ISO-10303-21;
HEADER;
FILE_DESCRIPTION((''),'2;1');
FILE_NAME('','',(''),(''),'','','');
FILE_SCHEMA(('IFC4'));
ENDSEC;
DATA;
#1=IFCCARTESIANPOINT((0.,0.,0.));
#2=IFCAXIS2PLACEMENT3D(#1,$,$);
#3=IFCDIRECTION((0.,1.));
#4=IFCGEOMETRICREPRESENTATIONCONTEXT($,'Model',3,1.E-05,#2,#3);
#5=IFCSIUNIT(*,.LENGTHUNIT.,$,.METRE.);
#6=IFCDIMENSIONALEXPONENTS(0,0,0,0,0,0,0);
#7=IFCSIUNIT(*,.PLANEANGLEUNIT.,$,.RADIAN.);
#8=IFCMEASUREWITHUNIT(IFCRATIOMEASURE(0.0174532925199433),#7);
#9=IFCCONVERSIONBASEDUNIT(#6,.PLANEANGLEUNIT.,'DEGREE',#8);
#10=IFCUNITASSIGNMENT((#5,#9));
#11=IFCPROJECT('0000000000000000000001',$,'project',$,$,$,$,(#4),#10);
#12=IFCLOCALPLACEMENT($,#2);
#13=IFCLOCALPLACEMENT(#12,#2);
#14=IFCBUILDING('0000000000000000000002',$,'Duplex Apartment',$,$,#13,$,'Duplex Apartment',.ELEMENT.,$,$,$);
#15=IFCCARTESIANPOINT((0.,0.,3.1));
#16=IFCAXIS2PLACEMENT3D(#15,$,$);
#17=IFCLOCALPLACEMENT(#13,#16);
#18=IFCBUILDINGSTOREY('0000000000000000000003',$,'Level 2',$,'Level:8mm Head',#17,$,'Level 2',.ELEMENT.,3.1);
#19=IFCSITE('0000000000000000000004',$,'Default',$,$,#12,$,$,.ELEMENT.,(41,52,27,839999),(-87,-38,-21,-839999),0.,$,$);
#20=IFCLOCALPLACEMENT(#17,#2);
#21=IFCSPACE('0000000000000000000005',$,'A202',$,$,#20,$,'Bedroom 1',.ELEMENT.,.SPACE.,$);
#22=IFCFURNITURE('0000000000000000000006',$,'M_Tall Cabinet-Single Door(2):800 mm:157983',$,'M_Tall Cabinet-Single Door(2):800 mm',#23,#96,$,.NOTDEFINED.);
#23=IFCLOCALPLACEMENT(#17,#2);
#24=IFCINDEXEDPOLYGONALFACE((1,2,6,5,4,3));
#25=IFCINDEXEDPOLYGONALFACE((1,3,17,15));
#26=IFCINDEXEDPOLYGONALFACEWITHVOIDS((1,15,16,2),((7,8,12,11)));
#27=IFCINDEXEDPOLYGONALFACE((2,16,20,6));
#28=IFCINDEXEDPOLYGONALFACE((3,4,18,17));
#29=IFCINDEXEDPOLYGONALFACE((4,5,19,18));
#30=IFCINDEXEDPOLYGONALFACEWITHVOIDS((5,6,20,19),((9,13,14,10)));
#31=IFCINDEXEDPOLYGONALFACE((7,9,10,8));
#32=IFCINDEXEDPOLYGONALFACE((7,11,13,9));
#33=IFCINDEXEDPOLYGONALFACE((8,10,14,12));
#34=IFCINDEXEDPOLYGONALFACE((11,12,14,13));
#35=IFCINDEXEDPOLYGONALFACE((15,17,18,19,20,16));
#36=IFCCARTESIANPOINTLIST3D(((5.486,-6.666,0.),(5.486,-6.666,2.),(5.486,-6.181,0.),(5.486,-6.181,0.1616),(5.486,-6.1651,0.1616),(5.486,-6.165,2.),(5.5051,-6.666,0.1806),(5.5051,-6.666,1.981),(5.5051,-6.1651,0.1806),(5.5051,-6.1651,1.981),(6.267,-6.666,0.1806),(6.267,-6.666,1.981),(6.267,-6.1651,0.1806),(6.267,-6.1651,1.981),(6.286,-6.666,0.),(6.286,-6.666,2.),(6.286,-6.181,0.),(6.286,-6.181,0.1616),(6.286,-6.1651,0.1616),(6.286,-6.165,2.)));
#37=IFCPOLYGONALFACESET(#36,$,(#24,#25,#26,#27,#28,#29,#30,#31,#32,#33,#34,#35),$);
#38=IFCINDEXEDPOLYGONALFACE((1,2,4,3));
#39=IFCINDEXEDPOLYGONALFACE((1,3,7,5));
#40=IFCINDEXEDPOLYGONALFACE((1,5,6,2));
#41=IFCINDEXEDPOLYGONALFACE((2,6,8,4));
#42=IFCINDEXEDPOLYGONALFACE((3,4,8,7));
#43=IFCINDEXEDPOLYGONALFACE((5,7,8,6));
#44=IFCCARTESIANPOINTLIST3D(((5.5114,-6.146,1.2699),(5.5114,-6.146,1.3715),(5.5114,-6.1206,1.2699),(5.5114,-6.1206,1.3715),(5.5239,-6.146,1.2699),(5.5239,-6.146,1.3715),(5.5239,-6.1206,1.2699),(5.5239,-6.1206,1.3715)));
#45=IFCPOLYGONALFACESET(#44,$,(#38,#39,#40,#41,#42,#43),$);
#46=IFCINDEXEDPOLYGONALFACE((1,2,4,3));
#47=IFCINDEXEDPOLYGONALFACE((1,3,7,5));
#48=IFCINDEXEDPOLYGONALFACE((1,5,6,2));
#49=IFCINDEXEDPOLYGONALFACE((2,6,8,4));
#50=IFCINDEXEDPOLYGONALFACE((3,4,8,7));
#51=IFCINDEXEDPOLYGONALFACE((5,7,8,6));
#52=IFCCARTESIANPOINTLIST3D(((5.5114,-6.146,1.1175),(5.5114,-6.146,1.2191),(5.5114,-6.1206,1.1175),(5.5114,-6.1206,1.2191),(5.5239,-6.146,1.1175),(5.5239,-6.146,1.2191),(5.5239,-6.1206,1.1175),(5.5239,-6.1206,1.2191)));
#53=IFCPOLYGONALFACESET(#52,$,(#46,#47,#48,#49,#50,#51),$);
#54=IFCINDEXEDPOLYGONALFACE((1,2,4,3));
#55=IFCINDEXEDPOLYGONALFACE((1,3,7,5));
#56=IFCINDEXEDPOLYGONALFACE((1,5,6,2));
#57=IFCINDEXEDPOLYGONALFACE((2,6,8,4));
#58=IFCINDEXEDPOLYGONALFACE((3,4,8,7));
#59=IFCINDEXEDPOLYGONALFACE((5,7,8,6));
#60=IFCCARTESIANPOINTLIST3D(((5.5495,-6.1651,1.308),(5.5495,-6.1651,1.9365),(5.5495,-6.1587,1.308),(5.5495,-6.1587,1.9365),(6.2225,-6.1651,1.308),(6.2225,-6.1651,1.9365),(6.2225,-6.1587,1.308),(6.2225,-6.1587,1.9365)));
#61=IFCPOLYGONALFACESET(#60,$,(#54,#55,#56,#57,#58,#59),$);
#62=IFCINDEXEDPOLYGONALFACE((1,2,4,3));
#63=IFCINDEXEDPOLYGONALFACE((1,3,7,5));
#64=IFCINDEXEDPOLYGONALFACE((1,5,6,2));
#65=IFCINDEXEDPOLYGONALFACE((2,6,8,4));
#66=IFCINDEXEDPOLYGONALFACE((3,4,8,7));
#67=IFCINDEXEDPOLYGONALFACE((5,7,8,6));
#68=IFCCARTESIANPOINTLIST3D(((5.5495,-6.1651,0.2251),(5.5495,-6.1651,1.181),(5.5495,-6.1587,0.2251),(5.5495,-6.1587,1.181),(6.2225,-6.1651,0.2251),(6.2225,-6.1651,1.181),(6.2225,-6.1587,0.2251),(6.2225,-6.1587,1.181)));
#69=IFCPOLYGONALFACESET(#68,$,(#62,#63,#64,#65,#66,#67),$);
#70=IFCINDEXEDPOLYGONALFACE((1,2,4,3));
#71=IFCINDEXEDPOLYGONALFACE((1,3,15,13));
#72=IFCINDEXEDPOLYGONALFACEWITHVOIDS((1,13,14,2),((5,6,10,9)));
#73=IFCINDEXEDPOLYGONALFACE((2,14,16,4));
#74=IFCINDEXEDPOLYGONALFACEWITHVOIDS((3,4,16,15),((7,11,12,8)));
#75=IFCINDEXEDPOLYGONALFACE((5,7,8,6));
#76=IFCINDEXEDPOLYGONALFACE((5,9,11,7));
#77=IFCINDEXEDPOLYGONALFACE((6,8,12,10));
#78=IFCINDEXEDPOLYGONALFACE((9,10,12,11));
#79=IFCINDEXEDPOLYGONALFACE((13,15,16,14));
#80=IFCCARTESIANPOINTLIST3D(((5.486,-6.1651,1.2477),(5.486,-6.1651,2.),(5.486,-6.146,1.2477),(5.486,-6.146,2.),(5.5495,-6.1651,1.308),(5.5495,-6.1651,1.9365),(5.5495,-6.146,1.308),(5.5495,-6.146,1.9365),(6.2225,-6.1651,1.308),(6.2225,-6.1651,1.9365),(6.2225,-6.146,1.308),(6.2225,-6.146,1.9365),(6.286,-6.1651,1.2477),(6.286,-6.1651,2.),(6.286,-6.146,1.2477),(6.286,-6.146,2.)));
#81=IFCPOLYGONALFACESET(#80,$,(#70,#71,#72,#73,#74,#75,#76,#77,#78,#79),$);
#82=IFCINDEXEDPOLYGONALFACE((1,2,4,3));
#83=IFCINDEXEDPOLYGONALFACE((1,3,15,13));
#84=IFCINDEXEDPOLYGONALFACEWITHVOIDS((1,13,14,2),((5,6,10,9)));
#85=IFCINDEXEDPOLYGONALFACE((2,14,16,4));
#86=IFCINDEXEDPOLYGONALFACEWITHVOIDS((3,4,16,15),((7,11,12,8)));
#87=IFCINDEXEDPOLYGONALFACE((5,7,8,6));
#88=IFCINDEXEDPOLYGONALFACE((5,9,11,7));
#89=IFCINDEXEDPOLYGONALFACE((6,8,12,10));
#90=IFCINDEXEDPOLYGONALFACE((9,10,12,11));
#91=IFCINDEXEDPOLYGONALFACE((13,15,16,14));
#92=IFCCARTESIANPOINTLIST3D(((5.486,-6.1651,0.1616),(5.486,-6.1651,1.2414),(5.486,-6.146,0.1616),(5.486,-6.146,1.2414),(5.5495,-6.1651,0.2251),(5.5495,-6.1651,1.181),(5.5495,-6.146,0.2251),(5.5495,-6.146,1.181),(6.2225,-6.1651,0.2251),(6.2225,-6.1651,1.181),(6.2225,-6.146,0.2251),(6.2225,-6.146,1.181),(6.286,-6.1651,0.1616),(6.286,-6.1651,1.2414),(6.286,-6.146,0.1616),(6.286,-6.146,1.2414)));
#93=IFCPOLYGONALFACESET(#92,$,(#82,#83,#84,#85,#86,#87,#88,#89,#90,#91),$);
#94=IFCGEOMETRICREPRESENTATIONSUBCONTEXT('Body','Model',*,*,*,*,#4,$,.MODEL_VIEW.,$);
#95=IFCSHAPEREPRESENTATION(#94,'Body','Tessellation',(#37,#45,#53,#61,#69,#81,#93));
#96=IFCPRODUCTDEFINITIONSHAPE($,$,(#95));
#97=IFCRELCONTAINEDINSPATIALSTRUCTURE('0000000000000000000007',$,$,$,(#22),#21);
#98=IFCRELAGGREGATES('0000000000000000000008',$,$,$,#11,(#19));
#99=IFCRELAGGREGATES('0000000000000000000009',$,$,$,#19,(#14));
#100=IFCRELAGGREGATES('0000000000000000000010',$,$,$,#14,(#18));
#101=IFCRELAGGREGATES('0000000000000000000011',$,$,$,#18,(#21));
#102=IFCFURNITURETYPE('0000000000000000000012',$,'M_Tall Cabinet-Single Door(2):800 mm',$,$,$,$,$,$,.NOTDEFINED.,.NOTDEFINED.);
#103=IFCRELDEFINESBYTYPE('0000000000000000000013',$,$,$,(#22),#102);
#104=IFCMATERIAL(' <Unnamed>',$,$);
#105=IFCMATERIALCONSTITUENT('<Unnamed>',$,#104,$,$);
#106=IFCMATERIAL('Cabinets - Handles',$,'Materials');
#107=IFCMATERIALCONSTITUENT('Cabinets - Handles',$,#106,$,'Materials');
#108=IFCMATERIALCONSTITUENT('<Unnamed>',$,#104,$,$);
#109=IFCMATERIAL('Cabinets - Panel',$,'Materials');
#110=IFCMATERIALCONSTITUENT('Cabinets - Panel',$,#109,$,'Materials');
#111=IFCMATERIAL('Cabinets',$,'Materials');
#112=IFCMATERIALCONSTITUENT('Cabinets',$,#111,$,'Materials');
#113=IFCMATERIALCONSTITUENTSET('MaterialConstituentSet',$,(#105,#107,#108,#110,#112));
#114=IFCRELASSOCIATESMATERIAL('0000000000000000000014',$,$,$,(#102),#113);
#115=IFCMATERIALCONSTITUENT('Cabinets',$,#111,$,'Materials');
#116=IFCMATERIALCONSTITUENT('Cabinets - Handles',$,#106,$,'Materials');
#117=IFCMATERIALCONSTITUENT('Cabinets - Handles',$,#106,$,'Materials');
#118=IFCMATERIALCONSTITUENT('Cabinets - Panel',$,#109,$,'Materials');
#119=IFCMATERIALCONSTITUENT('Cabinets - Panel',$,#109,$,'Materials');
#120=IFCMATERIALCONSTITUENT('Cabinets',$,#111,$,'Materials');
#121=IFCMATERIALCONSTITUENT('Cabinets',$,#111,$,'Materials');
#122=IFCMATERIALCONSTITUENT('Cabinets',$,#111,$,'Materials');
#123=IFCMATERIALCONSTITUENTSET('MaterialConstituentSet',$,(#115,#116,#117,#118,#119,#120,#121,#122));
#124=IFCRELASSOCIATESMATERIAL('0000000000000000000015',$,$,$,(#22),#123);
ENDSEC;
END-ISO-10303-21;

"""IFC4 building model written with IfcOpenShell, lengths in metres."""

from ifc_helpers import new_model, entity, si_unit, converted_unit, direction, frame, origin, place, context, subcontext, project, spatial, indexed_curve, outline, extrude, source, transform, mapped, material, constituent, constituent_set, type_object, type_shapes, element, save


model = new_model("IFC4")

# Units and contexts
model_context = context("Model", 3, precision=1e-05, world=origin(), true_north=direction((0.0, 1.0)))
body_context = subcontext(model_context, "Body", "Model", "MODEL_VIEW")
ifc_project = project(units=[si_unit("LENGTHUNIT", "METRE"), converted_unit("PLANEANGLEUNIT", "DEGREE", entity("IfcRatioMeasure", 0.0174532925199433), si_unit("PLANEANGLEUNIT", "RADIAN"), dimensions=[0, 0, 0, 0, 0, 0, 0])], contexts=[model_context])

# Site, building, storey
site_placement = place(None, origin())
site = spatial("IfcSite", under=ifc_project, at=site_placement, Name="Default", CompositionType="ELEMENT", RefLatitude=(41, 52, 27, 839999), RefLongitude=(-87, -38, -21, -839999), RefElevation=0.0)
building_placement = place(site_placement, origin())
building = spatial("IfcBuilding", under=site, at=building_placement, Name="Duplex Apartment", LongName="Duplex Apartment", CompositionType="ELEMENT")
storey_placement = place(building_placement, frame((0.0, 0.0, 3.1)))
storey = spatial("IfcBuildingStorey", under=building, at=storey_placement, Name="Level 2", ObjectType="Level:8mm Head", LongName="Level 2", CompositionType="ELEMENT", Elevation=3.1)

# Shared definitions
ifc_material_1 = material(Name="Cabinets", Category="Materials")
ifc_material_2 = material(Name="Cabinets - Handles", Category="Materials")
ifc_material_3 = material(Name="Cabinets - Panel", Category="Materials")
ifc_material_4 = material(Name=" <Unnamed>")

# Shared definitions
space_1_placement = place(storey_placement, origin())
space_1 = spatial("IfcSpace", under=storey, at=space_1_placement, Name="A202", LongName="Bedroom 1", CompositionType="ELEMENT", PredefinedType="SPACE")

# Furniture, opening
ifc_constituent_1 = constituent(ifc_material_1, Name="Cabinets", Category="Materials")
ifc_constituent_2 = constituent(ifc_material_2, Name="Cabinets - Handles", Category="Materials")
ifc_constituent_3 = constituent(ifc_material_2, Name="Cabinets - Handles", Category="Materials")
ifc_constituent_4 = constituent(ifc_material_3, Name="Cabinets - Panel", Category="Materials")
ifc_constituent_5 = constituent(ifc_material_3, Name="Cabinets - Panel", Category="Materials")
ifc_constituent_6 = constituent(ifc_material_1, Name="Cabinets", Category="Materials")
ifc_constituent_7 = constituent(ifc_material_1, Name="Cabinets", Category="Materials")
ifc_constituent_8 = constituent(ifc_material_1, Name="Cabinets", Category="Materials")
ifc_constituent_set_1 = constituent_set(constituents=[ifc_constituent_1, ifc_constituent_2, ifc_constituent_3, ifc_constituent_4, ifc_constituent_5, ifc_constituent_6, ifc_constituent_7, ifc_constituent_8], Name="MaterialConstituentSet")
ifc_constituent_9 = constituent(ifc_material_4, Name="<Unnamed>")
ifc_constituent_10 = constituent(ifc_material_2, Name="Cabinets - Handles", Category="Materials")
ifc_constituent_11 = constituent(ifc_material_4, Name="<Unnamed>")
ifc_constituent_12 = constituent(ifc_material_3, Name="Cabinets - Panel", Category="Materials")
ifc_constituent_13 = constituent(ifc_material_1, Name="Cabinets", Category="Materials")
ifc_constituent_set_2 = constituent_set(constituents=[ifc_constituent_9, ifc_constituent_10, ifc_constituent_11, ifc_constituent_12, ifc_constituent_13], Name="MaterialConstituentSet")
furniture_type_1 = type_object("IfcFurnitureType", Name="M_Tall Cabinet-Single Door(2):800 mm", AssemblyPlace="NOTDEFINED", PredefinedType="NOTDEFINED", material=ifc_constituent_set_2)
shared_shape_1 = source(origin(), body_context, "Body", "SweptSolid", [
    extrude(outline(indexed_curve([(-0.1723, 0.5589), (-0.1723, -1.2795), (0.3286, -1.2795), (0.3287, 0.7205), (-0.1563, 0.7205), (-0.1563, 0.5589), (-0.1723, 0.5589)], self_intersect=False)), frame((-0.3813, -0.3286, 0.7205), z_axis=(-1.0, 0.0, 0.0), x_axis=(0.0, 1.0, 0.0)), (0.0, 0.0, -1.0), 0.8),
    extrude(outline(indexed_curve([(-0.0127, -0.0063), (0.0127, -0.0063), (0.0127, 0.0063), (-0.0127, 0.0063), (-0.0127, -0.0063)], self_intersect=False)), frame((0.3871, -0.5327, 1.2699), z_axis=(0.0, 0.0, 1.0), x_axis=(0.0, 1.0, 0.0)), (0.0, 0.0, 1.0), 0.1016),
    extrude(outline(indexed_curve([(-0.0127, -0.0063), (0.0127, -0.0063), (0.0127, 0.0063), (-0.0127, 0.0063), (-0.0127, -0.0063)], self_intersect=False)), frame((0.3871, -0.5327, 1.1175), z_axis=(0.0, 0.0, 1.0), x_axis=(0.0, 1.0, 0.0)), (0.0, 0.0, 1.0), 0.1016),
    extrude(outline(indexed_curve([(-0.0032, -0.3365), (0.0032, -0.3365), (0.0032, 0.3365), (-0.0032, 0.3365), (-0.0032, -0.3365)], self_intersect=False)), frame((0.0187, -0.5041, 1.308), z_axis=(0.0, 0.0, 1.0), x_axis=(0.0, 1.0, 0.0)), (0.0, 0.0, 1.0), 0.6285),
    extrude(outline(indexed_curve([(-0.0032, -0.3365), (0.0032, -0.3365), (0.0032, 0.3365), (-0.0032, 0.3365), (-0.0032, -0.3365)], self_intersect=False)), frame((0.0187, -0.5041, 0.2251), z_axis=(0.0, 0.0, 1.0), x_axis=(0.0, 1.0, 0.0)), (0.0, 0.0, 1.0), 0.956),
    extrude(outline(indexed_curve([(-0.3761, -0.4), (0.3761, -0.4), (0.3761, 0.4), (-0.3761, 0.4), (-0.3761, -0.4)], self_intersect=False), holes=[indexed_curve([(-0.3126, -0.3365), (-0.3126, 0.3365), (0.3158, 0.3365), (0.3158, -0.3365), (-0.3126, -0.3365)], self_intersect=False)]), frame((0.0187, -0.52, 1.6239), z_axis=(0.0, 1.0, 0.0), x_axis=(0.0, 0.0, -1.0)), (0.0, 0.0, 1.0), 0.0191),
    extrude(outline(indexed_curve([(-0.4, -0.5399), (0.4, -0.5399), (0.4, 0.5399), (-0.4, 0.5399), (-0.4, -0.5399)], self_intersect=False), holes=[indexed_curve([(-0.3365, 0.4796), (0.3365, 0.4796), (0.3365, -0.4764), (-0.3365, -0.4764), (-0.3365, 0.4796)], self_intersect=False)]), frame((0.0187, -0.52, 0.7015), z_axis=(0.0, 1.0, 0.0), x_axis=(-1.0, 0.0, 0.0)), (0.0, 0.0, 1.0), 0.0191),
    extrude(outline(indexed_curve([(-0.0095, -0.381), (0.0095, -0.381), (0.0095, 0.381), (-0.0095, 0.381), (-0.0095, -0.381)], self_intersect=False)), frame((0.0187, -0.0095, 0.1806), z_axis=(0.0, 0.0, 1.0), x_axis=(0.0, 1.0, 0.0)), (0.0, 0.0, 1.0), 1.8003),
])
type_shapes(furniture_type_1, [shared_shape_1])
furniture_1_placement = place(space_1_placement, frame((5.9047, -6.666, 0.0), z_axis=(0.0, 0.0, 1.0), x_axis=(-1.0, 0.0, 0.0)))
furniture_1 = element("IfcFurniture", 1, at=furniture_1_placement, inside=space_1, type_object=furniture_type_1, material=ifc_constituent_set_1, Name="M_Tall Cabinet-Single Door(2):800 mm:157983", ObjectType="M_Tall Cabinet-Single Door(2):800 mm", PredefinedType="NOTDEFINED", context=body_context, shape_type="MappedRepresentation", body=[
    mapped(shared_shape_1, transform((0.0, 0.0, 0.0), scale=1.0)),
])
opening_1_placement = place(storey_placement, frame((5.9047, -6.666, 3.1)))
element("IfcOpeningElement", 2, at=opening_1_placement, cuts=furniture_1, ObjectType="Opening", PredefinedType="OPENING", context=body_context, shape_type="SweptSolid", body=[
    extrude(outline(indexed_curve([(-0.9002, -0.381), (0.9002, -0.381), (0.9002, 0.381), (-0.9002, 0.381), (-0.9002, -0.381)], self_intersect=False)), frame((-0.0187, 0.501, -2.0192), z_axis=(0.0, -1.0, 0.0), x_axis=(0.0, 0.0, -1.0)), (0.0, 0.0, 1.0), 0.501),
])

save(model, "model.ifc")
